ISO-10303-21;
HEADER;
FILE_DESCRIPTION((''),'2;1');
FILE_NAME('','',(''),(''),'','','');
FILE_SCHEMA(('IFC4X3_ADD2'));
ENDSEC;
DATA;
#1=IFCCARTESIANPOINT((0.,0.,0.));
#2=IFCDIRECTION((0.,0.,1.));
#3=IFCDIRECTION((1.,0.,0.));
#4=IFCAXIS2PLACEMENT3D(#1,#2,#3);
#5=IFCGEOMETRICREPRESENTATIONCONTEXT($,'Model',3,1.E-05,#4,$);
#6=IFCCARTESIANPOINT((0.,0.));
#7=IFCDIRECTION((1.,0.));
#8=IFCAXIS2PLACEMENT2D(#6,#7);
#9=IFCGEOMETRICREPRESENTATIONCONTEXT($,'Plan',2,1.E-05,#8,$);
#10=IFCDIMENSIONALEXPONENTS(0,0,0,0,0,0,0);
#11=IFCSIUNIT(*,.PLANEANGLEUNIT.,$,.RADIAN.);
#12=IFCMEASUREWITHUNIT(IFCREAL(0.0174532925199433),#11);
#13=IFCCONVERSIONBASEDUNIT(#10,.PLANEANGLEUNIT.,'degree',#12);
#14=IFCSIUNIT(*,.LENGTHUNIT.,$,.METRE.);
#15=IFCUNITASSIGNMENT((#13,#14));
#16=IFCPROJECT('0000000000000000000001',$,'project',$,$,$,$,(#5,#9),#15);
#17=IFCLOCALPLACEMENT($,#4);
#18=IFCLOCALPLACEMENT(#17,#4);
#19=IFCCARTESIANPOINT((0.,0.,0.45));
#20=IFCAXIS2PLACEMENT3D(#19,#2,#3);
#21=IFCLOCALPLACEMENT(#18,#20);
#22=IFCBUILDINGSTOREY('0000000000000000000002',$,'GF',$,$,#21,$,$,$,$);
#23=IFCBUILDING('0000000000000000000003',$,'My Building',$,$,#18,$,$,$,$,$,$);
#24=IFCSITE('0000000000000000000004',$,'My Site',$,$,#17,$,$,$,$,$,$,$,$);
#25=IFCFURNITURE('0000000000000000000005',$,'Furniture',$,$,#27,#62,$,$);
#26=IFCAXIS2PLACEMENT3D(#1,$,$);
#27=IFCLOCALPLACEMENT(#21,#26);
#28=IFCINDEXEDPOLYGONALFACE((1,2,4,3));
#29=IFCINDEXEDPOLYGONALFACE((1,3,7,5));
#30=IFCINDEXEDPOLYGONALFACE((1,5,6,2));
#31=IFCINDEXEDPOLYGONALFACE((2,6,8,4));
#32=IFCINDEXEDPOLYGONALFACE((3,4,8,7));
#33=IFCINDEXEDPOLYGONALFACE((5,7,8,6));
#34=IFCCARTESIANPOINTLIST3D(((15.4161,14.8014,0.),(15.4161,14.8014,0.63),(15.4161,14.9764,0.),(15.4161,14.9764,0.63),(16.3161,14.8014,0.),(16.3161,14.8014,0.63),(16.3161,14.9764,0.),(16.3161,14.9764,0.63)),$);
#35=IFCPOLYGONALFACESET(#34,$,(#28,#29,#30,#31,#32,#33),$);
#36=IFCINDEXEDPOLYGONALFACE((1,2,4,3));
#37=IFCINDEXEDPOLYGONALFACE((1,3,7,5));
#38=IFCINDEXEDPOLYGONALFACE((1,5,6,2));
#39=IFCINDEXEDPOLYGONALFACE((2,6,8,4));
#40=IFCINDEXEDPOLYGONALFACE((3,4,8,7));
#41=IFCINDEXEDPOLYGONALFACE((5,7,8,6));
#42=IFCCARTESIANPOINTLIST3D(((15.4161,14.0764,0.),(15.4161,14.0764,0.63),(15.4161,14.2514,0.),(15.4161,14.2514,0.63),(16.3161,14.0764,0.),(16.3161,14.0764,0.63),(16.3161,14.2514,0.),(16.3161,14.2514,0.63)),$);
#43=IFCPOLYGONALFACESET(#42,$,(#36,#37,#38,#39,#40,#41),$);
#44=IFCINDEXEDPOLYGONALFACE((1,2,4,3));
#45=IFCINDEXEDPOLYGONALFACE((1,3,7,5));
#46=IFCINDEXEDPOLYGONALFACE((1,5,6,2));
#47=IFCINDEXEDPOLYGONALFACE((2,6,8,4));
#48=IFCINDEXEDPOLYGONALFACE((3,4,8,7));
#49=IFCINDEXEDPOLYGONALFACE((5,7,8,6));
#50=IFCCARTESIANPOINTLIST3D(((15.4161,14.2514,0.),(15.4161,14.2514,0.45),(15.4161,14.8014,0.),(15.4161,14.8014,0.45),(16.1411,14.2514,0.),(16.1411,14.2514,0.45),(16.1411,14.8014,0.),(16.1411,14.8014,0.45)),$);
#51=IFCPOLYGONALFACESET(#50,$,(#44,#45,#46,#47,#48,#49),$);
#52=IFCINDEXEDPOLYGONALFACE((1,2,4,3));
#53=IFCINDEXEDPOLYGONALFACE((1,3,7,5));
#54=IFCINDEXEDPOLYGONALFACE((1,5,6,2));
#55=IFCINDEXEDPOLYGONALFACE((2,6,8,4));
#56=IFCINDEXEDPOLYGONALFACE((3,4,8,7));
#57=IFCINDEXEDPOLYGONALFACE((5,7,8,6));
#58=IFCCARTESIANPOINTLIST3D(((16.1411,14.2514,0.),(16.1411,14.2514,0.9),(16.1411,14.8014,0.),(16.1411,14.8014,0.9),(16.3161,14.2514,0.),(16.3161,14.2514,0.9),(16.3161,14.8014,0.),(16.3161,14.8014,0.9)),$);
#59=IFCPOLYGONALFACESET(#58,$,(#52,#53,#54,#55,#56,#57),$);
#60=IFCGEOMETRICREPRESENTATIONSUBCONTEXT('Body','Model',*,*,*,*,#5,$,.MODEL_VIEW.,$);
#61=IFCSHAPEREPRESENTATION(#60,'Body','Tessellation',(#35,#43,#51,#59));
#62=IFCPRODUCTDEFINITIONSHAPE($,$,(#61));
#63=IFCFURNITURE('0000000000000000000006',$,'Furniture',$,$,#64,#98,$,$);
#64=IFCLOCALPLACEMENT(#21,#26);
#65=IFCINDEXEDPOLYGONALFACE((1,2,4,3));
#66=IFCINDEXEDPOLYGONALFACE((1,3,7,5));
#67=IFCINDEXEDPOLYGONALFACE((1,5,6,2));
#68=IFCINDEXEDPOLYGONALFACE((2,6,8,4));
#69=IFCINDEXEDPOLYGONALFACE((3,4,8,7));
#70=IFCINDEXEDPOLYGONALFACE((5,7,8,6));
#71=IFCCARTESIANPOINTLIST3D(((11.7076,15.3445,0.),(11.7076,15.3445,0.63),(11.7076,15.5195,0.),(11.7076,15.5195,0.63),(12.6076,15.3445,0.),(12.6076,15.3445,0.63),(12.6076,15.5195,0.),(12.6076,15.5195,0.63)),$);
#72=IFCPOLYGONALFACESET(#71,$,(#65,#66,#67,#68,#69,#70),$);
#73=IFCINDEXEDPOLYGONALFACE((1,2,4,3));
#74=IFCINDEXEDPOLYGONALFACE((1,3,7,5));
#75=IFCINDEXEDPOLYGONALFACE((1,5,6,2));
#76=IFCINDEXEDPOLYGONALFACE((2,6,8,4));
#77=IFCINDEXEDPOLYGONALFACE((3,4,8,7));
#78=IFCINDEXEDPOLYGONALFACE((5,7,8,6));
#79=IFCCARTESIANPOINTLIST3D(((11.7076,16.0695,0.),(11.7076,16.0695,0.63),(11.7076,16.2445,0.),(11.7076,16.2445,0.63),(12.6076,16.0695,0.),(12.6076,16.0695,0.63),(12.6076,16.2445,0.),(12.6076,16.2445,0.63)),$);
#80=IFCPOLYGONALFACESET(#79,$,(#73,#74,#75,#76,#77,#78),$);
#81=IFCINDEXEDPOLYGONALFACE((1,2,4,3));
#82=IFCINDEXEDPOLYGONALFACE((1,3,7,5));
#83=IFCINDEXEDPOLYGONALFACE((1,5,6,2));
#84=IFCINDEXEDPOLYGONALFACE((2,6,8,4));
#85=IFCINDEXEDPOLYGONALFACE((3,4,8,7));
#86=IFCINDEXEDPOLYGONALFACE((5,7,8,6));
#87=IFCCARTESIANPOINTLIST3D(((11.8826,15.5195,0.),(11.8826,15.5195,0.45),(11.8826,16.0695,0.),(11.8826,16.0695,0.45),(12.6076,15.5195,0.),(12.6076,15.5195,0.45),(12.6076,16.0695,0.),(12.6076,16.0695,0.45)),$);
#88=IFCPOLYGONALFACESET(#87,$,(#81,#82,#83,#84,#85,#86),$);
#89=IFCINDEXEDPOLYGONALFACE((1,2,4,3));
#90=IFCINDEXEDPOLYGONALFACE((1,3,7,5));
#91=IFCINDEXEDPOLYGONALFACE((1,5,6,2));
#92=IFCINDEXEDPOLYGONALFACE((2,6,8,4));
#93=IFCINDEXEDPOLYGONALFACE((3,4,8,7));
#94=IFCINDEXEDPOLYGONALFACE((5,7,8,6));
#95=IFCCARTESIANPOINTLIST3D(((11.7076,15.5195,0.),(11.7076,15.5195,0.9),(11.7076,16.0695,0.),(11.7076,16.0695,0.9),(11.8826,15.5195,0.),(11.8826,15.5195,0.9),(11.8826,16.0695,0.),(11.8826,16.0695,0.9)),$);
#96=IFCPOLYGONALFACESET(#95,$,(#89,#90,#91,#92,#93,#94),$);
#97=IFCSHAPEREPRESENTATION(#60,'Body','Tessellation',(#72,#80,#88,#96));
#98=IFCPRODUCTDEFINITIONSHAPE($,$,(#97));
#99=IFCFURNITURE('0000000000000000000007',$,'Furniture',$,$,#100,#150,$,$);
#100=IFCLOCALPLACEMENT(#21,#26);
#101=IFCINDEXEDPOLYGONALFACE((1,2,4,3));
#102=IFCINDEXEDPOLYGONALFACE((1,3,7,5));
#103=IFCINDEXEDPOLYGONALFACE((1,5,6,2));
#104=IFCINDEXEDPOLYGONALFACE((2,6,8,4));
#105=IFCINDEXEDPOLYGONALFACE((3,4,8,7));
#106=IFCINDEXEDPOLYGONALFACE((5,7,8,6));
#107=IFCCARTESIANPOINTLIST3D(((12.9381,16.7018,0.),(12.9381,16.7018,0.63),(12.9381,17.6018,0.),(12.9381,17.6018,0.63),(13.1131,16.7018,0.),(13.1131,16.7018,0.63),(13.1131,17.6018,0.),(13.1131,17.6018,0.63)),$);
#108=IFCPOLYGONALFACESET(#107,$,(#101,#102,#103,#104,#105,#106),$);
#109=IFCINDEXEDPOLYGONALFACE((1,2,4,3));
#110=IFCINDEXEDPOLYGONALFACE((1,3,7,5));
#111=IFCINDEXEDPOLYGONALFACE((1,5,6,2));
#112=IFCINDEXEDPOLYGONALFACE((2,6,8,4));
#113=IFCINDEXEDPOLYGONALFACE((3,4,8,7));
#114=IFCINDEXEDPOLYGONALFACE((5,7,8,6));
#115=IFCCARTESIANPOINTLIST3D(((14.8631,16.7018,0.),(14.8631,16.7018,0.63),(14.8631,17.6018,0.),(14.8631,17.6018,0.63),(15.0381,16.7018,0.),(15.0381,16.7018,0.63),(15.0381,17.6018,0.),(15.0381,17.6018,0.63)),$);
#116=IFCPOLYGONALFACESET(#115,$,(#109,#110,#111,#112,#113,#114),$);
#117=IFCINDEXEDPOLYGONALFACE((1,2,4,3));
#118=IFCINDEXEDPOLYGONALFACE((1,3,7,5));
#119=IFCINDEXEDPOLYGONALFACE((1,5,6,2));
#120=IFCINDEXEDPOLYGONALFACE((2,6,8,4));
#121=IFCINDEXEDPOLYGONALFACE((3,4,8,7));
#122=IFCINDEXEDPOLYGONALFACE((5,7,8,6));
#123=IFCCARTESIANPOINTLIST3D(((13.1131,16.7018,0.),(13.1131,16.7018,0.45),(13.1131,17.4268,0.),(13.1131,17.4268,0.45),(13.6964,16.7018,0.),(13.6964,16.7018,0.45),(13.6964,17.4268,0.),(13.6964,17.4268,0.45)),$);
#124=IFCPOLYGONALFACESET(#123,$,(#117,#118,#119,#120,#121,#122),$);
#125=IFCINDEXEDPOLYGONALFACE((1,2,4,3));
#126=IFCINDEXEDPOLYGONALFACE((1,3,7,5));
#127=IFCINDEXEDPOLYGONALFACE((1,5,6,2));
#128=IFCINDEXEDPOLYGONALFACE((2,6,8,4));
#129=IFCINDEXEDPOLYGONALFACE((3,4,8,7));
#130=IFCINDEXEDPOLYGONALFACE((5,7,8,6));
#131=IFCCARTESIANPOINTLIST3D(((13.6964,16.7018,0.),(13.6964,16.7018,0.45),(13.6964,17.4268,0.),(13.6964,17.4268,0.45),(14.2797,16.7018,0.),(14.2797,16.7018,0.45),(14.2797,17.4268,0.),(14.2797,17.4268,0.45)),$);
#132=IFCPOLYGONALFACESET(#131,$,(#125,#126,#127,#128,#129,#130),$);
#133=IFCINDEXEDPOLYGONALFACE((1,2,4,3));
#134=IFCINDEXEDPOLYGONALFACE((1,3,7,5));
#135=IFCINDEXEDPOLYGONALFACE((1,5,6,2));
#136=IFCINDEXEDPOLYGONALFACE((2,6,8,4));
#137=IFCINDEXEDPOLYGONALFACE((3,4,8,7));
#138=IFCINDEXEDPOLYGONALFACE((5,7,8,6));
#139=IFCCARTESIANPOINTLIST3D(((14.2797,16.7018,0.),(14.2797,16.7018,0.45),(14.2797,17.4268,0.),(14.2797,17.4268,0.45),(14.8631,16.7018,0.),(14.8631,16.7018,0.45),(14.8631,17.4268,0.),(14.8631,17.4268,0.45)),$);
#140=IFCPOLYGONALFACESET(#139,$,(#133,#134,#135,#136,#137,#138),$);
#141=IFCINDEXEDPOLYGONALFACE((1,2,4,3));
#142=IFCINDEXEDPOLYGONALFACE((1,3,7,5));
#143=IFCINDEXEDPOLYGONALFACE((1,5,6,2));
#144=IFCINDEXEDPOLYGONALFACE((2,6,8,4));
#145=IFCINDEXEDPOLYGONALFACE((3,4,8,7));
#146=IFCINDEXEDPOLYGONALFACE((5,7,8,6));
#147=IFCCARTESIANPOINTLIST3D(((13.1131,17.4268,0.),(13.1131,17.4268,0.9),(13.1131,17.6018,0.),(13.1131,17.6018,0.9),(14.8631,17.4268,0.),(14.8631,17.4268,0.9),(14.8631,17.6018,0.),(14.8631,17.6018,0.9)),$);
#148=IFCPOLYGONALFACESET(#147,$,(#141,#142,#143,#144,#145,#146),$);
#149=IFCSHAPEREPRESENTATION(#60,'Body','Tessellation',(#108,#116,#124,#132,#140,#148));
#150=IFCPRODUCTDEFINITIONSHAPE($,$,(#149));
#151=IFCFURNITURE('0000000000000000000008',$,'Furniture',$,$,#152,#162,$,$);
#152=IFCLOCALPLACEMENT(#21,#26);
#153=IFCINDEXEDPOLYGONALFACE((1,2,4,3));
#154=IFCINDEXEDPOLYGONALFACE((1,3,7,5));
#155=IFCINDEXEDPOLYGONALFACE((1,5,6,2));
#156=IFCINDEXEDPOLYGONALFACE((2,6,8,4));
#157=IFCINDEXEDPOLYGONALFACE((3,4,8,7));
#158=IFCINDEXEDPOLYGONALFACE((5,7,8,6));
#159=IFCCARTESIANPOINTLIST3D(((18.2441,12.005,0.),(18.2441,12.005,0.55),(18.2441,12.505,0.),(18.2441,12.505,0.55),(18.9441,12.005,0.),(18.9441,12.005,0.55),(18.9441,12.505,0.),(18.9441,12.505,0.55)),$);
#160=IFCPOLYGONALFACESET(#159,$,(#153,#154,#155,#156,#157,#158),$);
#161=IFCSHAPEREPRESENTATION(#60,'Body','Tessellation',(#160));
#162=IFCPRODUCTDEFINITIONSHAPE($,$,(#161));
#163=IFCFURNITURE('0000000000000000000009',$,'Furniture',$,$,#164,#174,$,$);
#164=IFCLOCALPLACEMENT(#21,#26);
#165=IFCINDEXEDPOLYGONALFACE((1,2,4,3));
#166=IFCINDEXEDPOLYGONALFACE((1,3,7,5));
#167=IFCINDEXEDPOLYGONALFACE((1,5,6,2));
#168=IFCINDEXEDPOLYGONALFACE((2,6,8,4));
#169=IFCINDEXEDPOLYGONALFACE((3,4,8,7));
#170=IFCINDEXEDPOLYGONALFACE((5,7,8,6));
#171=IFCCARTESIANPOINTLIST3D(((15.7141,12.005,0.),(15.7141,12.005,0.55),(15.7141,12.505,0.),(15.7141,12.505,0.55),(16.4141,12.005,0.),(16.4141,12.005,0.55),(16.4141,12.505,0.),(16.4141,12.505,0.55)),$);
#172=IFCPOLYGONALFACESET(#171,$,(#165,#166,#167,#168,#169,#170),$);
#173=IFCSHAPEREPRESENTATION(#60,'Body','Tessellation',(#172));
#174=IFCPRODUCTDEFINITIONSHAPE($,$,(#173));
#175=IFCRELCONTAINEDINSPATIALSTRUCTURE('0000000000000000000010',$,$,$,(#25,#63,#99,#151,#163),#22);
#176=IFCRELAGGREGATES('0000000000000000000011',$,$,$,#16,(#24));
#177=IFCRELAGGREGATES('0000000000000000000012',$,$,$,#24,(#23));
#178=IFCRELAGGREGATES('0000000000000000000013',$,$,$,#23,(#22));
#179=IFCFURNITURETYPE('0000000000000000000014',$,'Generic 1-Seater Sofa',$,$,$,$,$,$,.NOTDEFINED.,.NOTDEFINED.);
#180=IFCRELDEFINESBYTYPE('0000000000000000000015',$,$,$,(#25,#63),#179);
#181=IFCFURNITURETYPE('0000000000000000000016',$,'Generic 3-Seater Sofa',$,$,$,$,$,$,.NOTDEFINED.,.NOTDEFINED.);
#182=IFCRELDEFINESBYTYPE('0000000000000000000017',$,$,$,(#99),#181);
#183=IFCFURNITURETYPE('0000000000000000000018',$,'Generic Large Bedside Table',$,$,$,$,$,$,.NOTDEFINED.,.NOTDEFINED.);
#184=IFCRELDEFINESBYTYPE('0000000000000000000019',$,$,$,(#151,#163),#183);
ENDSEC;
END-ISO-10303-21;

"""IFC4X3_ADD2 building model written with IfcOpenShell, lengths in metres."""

from ifc_helpers import new_model, entity, si_unit, converted_unit, frame, origin_with_axes, origin_2d_with_axis, place, context, subcontext, project, spatial, line, indexed_curve, outline, extrude, shape, source, transform, mapped, type_object, type_shapes, element, save


model = new_model("IFC4X3_ADD2")

# Units and contexts
model_context = context("Model", 3, precision=1e-05, world=origin_with_axes())
plan_context = context("Plan", 2, precision=1e-05, world=origin_2d_with_axis())
body_context_1 = subcontext(model_context, "Body", "Model", "MODEL_VIEW")
body_context_2 = subcontext(plan_context, "Body", "Plan", "PLAN_VIEW")
ifc_project = project(units=[converted_unit("PLANEANGLEUNIT", "degree", entity("IfcReal", 0.0174532925199433), si_unit("PLANEANGLEUNIT", "RADIAN"), dimensions=[0, 0, 0, 0, 0, 0, 0]), si_unit("LENGTHUNIT", "METRE")], contexts=[model_context, plan_context])

# Site, building, storey
site_placement = place(None, origin_with_axes())
site = spatial("IfcSite", under=ifc_project, at=site_placement, Name="My Site")
building_placement = place(site_placement, origin_with_axes())
building = spatial("IfcBuilding", under=site, at=building_placement, Name="My Building")
storey_placement = place(building_placement, frame((0.0, 0.0, 0.45), z_axis=(0.0, 0.0, 1.0), x_axis=(1.0, 0.0, 0.0)))
storey = spatial("IfcBuildingStorey", under=building, at=storey_placement, Name="GF")

# Furniture
furniture_type_1 = type_object("IfcFurnitureType", Name="Generic 1-Seater Sofa", AssemblyPlace="NOTDEFINED", PredefinedType="NOTDEFINED")
shared_shape_1 = source(origin_with_axes(), body_context_1, "Body", "SweptSolid", [
    extrude(outline(indexed_curve([(0.0, 0.0), (0.175, 0.0), (0.175, 0.9), (0.0, 0.9)], segments=[line(1, 2, 3, 4, 1)])), frame((-0.45, -0.9, 0.0), z_axis=(0.0, 0.0, 1.0), x_axis=(1.0, 0.0, 0.0)), (0.0, 0.0, 1.0), 0.63),
    extrude(outline(indexed_curve([(0.0, 0.0), (0.175, 0.0), (0.175, 0.9), (0.0, 0.9)], segments=[line(1, 2, 3, 4, 1)])), frame((0.275, -0.9, 0.0), z_axis=(0.0, 0.0, 1.0), x_axis=(1.0, 0.0, 0.0)), (0.0, 0.0, 1.0), 0.63),
    extrude(outline(indexed_curve([(0.175, 0.0), (0.725, 0.0), (0.725, 0.725), (0.175, 0.725)], segments=[line(1, 2, 3, 4, 1)])), frame((-0.45, -0.9, 0.0), z_axis=(0.0, 0.0, 1.0), x_axis=(1.0, 0.0, 0.0)), (0.0, 0.0, 1.0), 0.45),
    extrude(outline(indexed_curve([(0.175, 0.725), (0.725, 0.725), (0.725, 0.9), (0.175, 0.9)], segments=[line(1, 2, 3, 4, 1)])), frame((-0.45, -0.9, 0.0), z_axis=(0.0, 0.0, 1.0), x_axis=(1.0, 0.0, 0.0)), (0.0, 0.0, 1.0), 0.9),
])
shared_shape_2 = source(origin_with_axes(), body_context_2, "Body", "Annotation2D", [
    entity("IfcGeometricCurveSet", [entity("IfcIndexedPolyCurve", entity("IfcCartesianPointList2D", [[0.275, -0.175], [0.275, -0.9], [0.45, -0.9], [0.45, 0.0], [0.275, 0.0], [0.275, -0.9], [-0.275, -0.9], [-0.275, 0.0], [-0.275, -0.175], [0.275, -0.175], [0.275, 0.0], [-0.275, 0.0], [-0.45, 0.0], [-0.45, -0.9], [-0.275, -0.9], [-0.275, -0.175]]))]),
])
type_shapes(furniture_type_1, [shared_shape_1, shared_shape_2])
for number, where, z_axis, x_axis, name in (
    (1, (16.3161, 14.5264, 0.0), (0.0, 0.0, 1.0), (0.0, -1.0, 0.0), "Furniture"),
    (2, (11.7076, 15.7945, 0.0), (0.0, 0.0, 1.0), (0.000003, 1.0, 0.0), "Furniture"),
):
    element("IfcFurniture", number, at=place(storey_placement, frame(where, z_axis=z_axis, x_axis=x_axis)), inside=storey, type_object=furniture_type_1, Name=name, shapes=[
        shape(body_context_1, "Body", "MappedRepresentation", [mapped(shared_shape_1, transform((0.0, 0.0, 0.0), x_axis=(1.0, 0.0, 0.0), y_axis=(0.0, 1.0, 0.0), z_axis=(0.0, 0.0, 1.0), scale=1.0))]),
        shape(body_context_2, "Body", "MappedRepresentation", [mapped(shared_shape_2, transform((0.0, 0.0, 0.0), x_axis=(1.0, 0.0, 0.0), y_axis=(0.0, 1.0, 0.0), z_axis=(0.0, 0.0, 1.0), scale=1.0))]),
    ])
furniture_type_2 = type_object("IfcFurnitureType", Name="Generic 3-Seater Sofa", AssemblyPlace="NOTDEFINED", PredefinedType="NOTDEFINED")
shared_shape_3 = source(origin_with_axes(), body_context_1, "Body", "SweptSolid", [
    extrude(outline(indexed_curve([(0.0, 0.0), (0.175, 0.0), (0.175, 0.9), (0.0, 0.9)], segments=[line(1, 2, 3, 4, 1)])), frame((-1.05, -0.9, 0.0), z_axis=(0.0, 0.0, 1.0), x_axis=(1.0, 0.0, 0.0)), (0.0, 0.0, 1.0), 0.63),
    extrude(outline(indexed_curve([(0.0, 0.0), (0.175, 0.0), (0.175, 0.9), (0.0, 0.9)], segments=[line(1, 2, 3, 4, 1)])), frame((0.875, -0.9, 0.0), z_axis=(0.0, 0.0, 1.0), x_axis=(1.0, 0.0, 0.0)), (0.0, 0.0, 1.0), 0.63),
    extrude(outline(indexed_curve([(0.175, 0.0), (0.7583, 0.0), (0.7583, 0.725), (0.175, 0.725)], segments=[line(1, 2, 3, 4, 1)])), frame((-1.05, -0.9, 0.0), z_axis=(0.0, 0.0, 1.0), x_axis=(1.0, 0.0, 0.0)), (0.0, 0.0, 1.0), 0.45),
    extrude(outline(indexed_curve([(0.7583, 0.0), (1.3417, 0.0), (1.3417, 0.725), (0.7583, 0.725)], segments=[line(1, 2, 3, 4, 1)])), frame((-1.05, -0.9, 0.0), z_axis=(0.0, 0.0, 1.0), x_axis=(1.0, 0.0, 0.0)), (0.0, 0.0, 1.0), 0.45),
    extrude(outline(indexed_curve([(1.3417, 0.0), (1.925, 0.0), (1.925, 0.725), (1.3417, 0.725)], segments=[line(1, 2, 3, 4, 1)])), frame((-1.05, -0.9, 0.0), z_axis=(0.0, 0.0, 1.0), x_axis=(1.0, 0.0, 0.0)), (0.0, 0.0, 1.0), 0.45),
    extrude(outline(indexed_curve([(0.175, 0.725), (1.925, 0.725), (1.925, 0.9), (0.175, 0.9)], segments=[line(1, 2, 3, 4, 1)])), frame((-1.05, -0.9, 0.0), z_axis=(0.0, 0.0, 1.0), x_axis=(1.0, 0.0, 0.0)), (0.0, 0.0, 1.0), 0.9),
])
shared_shape_4 = source(origin_with_axes(), body_context_2, "Body", "Curve2D", [
    entity("IfcIndexedPolyCurve", entity("IfcCartesianPointList2D", [[-1.05, -0.9], [-0.875, -0.9], [-0.875, 0.0], [-1.05, 0.0]]), [entity("IfcLineIndex", [1, 2, 3, 4, 1])]),
    entity("IfcIndexedPolyCurve", entity("IfcCartesianPointList2D", [[0.875, -0.9], [1.05, -0.9], [1.05, 0.0], [0.875, 0.0]]), [entity("IfcLineIndex", [1, 2, 3, 4, 1])]),
    entity("IfcIndexedPolyCurve", entity("IfcCartesianPointList2D", [[-0.875, -0.9], [-0.2917, -0.9], [-0.2917, -0.175], [-0.875, -0.175]]), [entity("IfcLineIndex", [1, 2, 3, 4, 1])]),
    entity("IfcIndexedPolyCurve", entity("IfcCartesianPointList2D", [[-0.2917, -0.9], [0.2917, -0.9], [0.2917, -0.175], [-0.2917, -0.175]]), [entity("IfcLineIndex", [1, 2, 3, 4, 1])]),
    entity("IfcIndexedPolyCurve", entity("IfcCartesianPointList2D", [[0.2917, -0.9], [0.875, -0.9], [0.875, -0.175], [0.2917, -0.175]]), [entity("IfcLineIndex", [1, 2, 3, 4, 1])]),
    entity("IfcIndexedPolyCurve", entity("IfcCartesianPointList2D", [[-0.875, -0.175], [0.875, -0.175], [0.875, 0.0], [-0.875, 0.0]]), [entity("IfcLineIndex", [1, 2, 3, 4, 1])]),
])
type_shapes(furniture_type_2, [shared_shape_3, shared_shape_4])
furniture_1_placement = place(storey_placement, frame((13.9881, 17.6018, 0.0), z_axis=(0.0, 0.0, 1.0), x_axis=(1.0, 0.0, 0.0)))
element("IfcFurniture", 3, at=furniture_1_placement, inside=storey, type_object=furniture_type_2, Name="Furniture", shapes=[
    shape(body_context_1, "Body", "MappedRepresentation", [mapped(shared_shape_3, transform((0.0, 0.0, 0.0), x_axis=(1.0, 0.0, 0.0), y_axis=(0.0, 1.0, 0.0), z_axis=(0.0, 0.0, 1.0), scale=1.0))]),
    shape(body_context_2, "Body", "MappedRepresentation", [mapped(shared_shape_4, transform((0.0, 0.0, 0.0), x_axis=(1.0, 0.0, 0.0), y_axis=(0.0, 1.0, 0.0), z_axis=(0.0, 0.0, 1.0), scale=1.0))]),
])
furniture_type_3 = type_object("IfcFurnitureType", Name="Generic Large Bedside Table", AssemblyPlace="NOTDEFINED", PredefinedType="NOTDEFINED")
shared_shape_5 = source(origin_with_axes(), body_context_1, "Body", "SweptSolid", [
    extrude(outline(indexed_curve([(0.0, 0.0), (0.7, 0.0), (0.7, 0.5), (0.0, 0.5)], segments=[line(1, 2, 3, 4, 1)])), frame((-0.35, -0.25, 0.0), z_axis=(0.0, 0.0, 1.0), x_axis=(1.0, 0.0, 0.0)), (0.0, 0.0, 1.0), 0.55),
])
shared_shape_6 = source(origin_with_axes(), body_context_2, "Body", "Curve2D", [
    entity("IfcIndexedPolyCurve", entity("IfcCartesianPointList2D", [[-0.35, -0.25], [0.35, -0.25], [0.35, 0.25], [-0.35, 0.25]]), [entity("IfcLineIndex", [1, 2, 3, 4, 1])]),
])
type_shapes(furniture_type_3, [shared_shape_5, shared_shape_6])
for number, where, z_axis, x_axis, name in (
    (4, (18.5941, 12.255, 0.0), (0.0, 0.0, 1.0), (1.0, 0.0, 0.0), "Furniture"),
    (5, (16.0641, 12.255, 0.0), (0.0, 0.0, 1.0), (1.0, 0.0, 0.0), "Furniture"),
):
    element("IfcFurniture", number, at=place(storey_placement, frame(where, z_axis=z_axis, x_axis=x_axis)), inside=storey, type_object=furniture_type_3, Name=name, shapes=[
        shape(body_context_1, "Body", "MappedRepresentation", [mapped(shared_shape_5, transform((0.0, 0.0, 0.0), x_axis=(1.0, 0.0, 0.0), y_axis=(0.0, 1.0, 0.0), z_axis=(0.0, 0.0, 1.0), scale=1.0))]),
        shape(body_context_2, "Body", "MappedRepresentation", [mapped(shared_shape_6, transform((0.0, 0.0, 0.0), x_axis=(1.0, 0.0, 0.0), y_axis=(0.0, 1.0, 0.0), z_axis=(0.0, 0.0, 1.0), scale=1.0))]),
    ])

save(model, "model.ifc")
